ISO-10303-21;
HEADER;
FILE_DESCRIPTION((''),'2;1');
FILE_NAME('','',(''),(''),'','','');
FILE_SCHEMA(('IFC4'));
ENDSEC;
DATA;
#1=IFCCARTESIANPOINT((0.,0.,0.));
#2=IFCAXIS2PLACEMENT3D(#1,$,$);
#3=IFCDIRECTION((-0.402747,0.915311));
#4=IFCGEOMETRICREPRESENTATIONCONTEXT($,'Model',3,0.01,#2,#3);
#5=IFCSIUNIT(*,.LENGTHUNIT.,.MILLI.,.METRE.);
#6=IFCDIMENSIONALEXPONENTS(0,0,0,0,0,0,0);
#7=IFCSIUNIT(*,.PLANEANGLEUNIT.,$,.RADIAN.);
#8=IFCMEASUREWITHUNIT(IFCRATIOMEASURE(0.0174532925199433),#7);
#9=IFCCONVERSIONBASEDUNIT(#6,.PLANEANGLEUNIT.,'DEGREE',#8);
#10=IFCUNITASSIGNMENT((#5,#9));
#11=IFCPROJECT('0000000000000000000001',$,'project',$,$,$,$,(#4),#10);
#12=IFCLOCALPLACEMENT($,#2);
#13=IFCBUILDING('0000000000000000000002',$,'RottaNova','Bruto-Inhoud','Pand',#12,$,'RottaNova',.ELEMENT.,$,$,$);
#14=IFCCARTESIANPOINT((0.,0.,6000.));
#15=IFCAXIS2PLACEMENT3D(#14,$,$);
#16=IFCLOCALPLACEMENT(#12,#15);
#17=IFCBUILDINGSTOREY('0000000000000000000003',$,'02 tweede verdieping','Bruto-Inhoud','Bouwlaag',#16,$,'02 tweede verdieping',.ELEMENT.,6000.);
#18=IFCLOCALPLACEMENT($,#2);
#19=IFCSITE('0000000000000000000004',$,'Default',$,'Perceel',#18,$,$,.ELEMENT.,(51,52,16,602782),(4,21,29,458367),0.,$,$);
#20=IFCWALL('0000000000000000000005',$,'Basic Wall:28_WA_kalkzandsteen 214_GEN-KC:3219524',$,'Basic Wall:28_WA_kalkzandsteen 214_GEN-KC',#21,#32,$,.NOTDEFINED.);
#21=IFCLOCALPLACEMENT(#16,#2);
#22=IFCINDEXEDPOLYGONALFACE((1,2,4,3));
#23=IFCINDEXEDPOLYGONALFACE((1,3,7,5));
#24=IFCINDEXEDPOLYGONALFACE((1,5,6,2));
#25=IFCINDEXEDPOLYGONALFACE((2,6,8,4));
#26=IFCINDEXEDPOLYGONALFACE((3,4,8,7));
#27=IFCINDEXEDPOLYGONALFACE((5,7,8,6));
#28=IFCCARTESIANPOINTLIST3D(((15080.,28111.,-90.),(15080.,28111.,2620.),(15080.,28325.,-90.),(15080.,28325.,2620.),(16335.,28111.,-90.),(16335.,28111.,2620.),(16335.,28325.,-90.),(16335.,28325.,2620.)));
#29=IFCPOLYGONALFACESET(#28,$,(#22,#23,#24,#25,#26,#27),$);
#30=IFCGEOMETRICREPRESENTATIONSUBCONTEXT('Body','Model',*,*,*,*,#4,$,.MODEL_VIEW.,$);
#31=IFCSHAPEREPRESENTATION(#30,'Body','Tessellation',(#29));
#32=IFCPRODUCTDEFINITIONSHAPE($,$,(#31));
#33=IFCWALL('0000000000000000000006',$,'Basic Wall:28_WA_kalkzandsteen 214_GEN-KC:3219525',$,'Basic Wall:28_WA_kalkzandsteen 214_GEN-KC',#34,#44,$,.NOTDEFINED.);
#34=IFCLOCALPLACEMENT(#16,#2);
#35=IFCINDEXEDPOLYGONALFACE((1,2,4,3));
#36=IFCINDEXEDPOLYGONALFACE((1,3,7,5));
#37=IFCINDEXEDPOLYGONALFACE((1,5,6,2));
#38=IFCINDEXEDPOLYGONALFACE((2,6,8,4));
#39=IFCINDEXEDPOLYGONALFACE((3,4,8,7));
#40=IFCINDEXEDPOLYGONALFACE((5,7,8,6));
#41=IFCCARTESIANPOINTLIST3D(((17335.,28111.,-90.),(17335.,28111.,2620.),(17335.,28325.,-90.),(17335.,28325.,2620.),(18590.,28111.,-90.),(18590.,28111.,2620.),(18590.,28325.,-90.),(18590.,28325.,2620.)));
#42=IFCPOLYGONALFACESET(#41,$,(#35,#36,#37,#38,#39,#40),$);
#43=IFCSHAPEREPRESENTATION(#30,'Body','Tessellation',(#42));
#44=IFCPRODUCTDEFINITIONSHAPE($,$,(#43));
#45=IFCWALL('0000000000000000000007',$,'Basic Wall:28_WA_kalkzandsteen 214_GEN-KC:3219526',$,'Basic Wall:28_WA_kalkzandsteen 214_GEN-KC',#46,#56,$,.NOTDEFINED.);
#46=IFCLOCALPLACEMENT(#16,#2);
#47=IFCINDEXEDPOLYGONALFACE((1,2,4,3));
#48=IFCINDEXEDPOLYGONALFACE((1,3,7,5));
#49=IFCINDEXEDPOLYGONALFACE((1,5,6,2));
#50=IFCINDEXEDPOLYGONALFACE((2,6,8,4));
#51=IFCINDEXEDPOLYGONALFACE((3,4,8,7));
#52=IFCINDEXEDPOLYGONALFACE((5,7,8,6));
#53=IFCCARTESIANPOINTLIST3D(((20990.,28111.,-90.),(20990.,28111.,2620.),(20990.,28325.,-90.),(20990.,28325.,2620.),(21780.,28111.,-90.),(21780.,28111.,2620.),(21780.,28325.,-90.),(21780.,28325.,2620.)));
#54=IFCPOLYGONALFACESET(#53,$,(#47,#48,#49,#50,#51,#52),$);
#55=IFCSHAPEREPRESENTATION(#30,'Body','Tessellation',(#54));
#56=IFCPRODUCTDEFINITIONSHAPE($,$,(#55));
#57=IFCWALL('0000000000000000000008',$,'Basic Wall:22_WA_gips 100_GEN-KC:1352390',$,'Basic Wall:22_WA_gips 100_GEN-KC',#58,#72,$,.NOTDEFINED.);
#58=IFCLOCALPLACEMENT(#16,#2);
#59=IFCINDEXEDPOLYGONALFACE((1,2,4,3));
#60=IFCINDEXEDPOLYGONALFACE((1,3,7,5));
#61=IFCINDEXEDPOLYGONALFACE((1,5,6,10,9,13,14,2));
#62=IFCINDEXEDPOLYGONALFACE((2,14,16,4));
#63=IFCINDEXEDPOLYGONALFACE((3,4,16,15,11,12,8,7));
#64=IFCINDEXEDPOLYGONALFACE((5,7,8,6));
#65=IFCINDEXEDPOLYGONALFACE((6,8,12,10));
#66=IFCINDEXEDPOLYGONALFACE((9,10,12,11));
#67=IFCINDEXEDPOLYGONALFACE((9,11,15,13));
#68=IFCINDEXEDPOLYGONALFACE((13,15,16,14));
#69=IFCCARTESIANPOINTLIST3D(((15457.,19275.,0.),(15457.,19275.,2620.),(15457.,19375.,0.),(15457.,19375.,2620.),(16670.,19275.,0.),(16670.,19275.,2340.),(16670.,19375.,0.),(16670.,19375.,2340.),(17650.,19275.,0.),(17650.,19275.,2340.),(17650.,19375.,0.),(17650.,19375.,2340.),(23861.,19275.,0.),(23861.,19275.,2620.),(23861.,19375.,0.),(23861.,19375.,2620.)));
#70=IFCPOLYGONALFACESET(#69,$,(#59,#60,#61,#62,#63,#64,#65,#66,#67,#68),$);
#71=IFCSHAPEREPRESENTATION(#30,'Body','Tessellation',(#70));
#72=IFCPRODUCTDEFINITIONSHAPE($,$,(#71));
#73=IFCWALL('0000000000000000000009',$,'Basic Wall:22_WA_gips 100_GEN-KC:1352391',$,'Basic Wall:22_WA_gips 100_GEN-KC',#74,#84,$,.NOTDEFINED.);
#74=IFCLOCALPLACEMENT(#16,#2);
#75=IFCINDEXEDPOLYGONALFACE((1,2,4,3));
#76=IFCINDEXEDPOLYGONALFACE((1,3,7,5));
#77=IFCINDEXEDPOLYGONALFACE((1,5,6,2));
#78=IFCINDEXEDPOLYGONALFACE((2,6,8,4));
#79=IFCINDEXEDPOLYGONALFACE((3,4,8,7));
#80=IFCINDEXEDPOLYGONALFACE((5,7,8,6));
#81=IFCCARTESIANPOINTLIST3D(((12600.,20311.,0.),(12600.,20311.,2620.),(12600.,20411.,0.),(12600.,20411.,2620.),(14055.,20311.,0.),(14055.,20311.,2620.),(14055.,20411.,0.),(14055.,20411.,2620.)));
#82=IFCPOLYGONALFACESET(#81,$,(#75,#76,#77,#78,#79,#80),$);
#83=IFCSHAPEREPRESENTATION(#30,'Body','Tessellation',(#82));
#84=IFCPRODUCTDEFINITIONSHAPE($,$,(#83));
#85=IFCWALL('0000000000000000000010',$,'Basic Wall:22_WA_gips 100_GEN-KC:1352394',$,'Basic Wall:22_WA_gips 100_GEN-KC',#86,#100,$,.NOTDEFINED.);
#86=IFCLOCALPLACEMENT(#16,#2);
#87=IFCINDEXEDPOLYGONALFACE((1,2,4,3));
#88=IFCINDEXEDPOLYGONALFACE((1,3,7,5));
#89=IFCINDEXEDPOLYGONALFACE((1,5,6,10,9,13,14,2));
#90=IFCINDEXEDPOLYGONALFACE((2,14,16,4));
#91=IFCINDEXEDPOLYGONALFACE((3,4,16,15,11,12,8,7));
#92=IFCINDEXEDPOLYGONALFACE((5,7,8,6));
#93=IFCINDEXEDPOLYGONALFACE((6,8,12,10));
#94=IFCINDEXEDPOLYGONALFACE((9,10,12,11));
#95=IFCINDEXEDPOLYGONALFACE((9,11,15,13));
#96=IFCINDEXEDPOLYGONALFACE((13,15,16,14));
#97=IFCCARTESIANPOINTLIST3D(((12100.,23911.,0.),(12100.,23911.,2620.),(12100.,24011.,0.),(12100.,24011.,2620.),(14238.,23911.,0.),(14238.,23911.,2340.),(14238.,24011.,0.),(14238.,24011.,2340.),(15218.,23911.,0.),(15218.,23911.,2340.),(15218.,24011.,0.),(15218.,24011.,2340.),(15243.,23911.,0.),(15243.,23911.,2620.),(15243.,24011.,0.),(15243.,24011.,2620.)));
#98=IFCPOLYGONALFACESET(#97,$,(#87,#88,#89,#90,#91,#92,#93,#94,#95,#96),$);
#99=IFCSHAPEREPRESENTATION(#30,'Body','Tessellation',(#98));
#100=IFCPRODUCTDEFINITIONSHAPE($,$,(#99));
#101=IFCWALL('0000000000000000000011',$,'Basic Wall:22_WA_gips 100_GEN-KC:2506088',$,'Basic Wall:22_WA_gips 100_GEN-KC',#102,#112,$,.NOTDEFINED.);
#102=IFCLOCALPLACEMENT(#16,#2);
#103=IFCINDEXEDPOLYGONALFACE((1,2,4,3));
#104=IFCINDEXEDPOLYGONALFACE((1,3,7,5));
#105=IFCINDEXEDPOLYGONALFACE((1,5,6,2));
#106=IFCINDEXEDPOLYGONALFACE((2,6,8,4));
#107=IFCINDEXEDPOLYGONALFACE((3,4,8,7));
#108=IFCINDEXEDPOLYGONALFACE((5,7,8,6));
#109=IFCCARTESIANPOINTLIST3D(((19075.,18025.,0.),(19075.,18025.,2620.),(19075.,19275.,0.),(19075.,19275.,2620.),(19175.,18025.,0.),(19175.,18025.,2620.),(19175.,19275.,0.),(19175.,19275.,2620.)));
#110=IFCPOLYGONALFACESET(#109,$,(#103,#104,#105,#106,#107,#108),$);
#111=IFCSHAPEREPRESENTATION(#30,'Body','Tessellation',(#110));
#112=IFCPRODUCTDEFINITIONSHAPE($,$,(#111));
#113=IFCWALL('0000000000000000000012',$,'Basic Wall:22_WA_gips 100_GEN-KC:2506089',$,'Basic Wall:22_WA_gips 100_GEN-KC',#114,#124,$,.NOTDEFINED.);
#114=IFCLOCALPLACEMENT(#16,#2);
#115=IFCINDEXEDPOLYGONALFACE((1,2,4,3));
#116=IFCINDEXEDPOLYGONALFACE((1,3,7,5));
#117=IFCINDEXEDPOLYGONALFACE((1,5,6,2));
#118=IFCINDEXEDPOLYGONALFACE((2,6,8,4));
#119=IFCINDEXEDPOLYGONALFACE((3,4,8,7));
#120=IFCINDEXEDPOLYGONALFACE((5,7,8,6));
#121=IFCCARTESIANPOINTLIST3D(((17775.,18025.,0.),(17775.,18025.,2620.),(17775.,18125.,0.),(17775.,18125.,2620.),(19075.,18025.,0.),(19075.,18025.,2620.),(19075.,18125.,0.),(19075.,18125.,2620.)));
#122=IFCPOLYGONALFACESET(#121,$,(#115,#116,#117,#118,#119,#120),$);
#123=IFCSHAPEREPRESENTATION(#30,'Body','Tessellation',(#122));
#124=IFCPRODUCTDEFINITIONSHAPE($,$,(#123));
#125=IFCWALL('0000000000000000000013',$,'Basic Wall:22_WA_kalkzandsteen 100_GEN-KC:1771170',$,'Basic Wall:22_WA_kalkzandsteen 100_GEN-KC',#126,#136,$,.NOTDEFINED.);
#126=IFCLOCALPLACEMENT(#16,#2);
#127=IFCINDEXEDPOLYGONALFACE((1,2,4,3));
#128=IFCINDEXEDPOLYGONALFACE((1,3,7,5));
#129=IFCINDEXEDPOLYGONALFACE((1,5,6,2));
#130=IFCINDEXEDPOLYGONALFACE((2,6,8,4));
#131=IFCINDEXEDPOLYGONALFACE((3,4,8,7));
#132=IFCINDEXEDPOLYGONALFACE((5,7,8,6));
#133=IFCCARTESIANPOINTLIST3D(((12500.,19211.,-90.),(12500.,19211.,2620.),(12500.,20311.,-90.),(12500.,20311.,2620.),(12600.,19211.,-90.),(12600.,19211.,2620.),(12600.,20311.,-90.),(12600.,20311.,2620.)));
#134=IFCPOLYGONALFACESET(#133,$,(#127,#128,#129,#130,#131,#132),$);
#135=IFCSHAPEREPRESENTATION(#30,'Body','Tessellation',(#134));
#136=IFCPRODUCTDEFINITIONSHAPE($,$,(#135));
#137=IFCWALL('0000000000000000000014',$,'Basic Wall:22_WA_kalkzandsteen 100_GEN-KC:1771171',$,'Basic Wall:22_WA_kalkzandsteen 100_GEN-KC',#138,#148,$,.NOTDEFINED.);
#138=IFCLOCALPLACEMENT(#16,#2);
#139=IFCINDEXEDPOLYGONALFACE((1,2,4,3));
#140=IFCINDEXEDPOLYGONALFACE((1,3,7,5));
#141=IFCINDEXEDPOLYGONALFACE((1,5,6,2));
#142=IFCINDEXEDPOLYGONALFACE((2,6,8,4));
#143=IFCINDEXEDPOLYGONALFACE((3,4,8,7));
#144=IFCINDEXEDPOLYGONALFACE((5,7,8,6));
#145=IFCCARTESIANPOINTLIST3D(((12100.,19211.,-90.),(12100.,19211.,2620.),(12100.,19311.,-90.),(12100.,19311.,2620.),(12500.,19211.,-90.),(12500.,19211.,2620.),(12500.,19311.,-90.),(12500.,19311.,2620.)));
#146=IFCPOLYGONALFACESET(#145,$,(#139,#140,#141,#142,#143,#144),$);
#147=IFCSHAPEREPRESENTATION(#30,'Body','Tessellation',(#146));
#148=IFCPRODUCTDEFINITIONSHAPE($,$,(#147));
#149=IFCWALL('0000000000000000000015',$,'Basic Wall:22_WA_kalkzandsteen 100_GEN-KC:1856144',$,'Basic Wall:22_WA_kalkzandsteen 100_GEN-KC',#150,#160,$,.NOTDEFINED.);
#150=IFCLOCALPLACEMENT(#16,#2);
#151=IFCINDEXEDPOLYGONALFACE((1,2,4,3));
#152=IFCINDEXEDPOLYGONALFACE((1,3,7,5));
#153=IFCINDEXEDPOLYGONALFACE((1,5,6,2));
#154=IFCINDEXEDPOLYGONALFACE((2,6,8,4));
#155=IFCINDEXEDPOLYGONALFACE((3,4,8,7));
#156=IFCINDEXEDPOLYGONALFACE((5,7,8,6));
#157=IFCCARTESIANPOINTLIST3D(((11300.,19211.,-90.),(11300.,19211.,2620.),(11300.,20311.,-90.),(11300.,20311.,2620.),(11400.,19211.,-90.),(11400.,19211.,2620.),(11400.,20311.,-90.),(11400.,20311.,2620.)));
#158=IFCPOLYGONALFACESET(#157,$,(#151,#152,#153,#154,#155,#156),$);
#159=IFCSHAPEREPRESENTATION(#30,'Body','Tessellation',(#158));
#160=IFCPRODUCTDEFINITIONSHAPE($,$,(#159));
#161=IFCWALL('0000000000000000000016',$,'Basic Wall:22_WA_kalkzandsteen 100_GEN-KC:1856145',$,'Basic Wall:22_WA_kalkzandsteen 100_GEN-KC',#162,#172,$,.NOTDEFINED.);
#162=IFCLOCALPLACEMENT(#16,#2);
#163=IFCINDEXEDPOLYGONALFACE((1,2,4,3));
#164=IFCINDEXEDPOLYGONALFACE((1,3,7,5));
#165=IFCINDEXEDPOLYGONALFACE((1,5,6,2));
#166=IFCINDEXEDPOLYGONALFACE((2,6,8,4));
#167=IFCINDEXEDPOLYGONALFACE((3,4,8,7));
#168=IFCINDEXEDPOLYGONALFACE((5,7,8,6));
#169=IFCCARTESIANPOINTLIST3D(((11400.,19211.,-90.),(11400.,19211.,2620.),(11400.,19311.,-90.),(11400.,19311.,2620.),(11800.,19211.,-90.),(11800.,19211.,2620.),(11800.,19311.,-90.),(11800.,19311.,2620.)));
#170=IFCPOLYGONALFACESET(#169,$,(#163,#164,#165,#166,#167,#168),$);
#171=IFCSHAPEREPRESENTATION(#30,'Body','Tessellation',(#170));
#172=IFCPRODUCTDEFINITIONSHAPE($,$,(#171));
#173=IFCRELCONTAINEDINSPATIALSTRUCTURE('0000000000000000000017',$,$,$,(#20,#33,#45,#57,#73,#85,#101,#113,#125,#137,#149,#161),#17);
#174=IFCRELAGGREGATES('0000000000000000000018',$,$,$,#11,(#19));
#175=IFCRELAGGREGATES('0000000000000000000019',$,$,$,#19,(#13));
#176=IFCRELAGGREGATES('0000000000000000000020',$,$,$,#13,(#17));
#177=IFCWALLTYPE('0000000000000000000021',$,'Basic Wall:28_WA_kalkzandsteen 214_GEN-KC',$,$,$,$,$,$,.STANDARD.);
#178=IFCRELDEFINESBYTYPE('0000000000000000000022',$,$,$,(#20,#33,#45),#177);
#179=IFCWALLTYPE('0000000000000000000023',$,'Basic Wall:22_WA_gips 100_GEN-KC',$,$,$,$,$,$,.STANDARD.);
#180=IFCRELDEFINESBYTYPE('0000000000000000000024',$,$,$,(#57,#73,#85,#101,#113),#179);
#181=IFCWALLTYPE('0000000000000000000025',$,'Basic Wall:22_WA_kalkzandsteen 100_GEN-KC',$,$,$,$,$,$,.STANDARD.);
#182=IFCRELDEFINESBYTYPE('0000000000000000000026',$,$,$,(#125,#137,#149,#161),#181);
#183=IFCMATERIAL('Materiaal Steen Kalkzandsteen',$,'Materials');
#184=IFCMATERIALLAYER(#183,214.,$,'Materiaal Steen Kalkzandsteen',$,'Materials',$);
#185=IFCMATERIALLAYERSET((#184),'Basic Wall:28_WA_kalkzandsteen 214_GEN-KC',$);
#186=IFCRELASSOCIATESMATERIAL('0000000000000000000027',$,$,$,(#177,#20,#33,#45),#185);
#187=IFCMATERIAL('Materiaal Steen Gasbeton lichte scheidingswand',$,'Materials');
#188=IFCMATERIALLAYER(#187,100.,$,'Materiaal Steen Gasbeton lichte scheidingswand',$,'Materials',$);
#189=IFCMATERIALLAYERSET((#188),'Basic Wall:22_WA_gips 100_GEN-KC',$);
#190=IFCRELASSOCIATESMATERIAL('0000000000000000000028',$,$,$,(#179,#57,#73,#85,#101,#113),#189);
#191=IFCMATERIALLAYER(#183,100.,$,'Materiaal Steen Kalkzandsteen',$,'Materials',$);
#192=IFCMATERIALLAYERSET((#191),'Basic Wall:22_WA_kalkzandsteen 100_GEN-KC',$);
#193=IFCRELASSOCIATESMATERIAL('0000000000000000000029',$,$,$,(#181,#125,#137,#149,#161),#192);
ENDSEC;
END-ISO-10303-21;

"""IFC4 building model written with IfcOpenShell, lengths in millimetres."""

from ifc_helpers import new_model, entity, si_unit, converted_unit, direction, frame, frame_2d, origin, place, context, subcontext, project, spatial, rectangle, extrude, material, layer, layer_set, type_object, element, save


model = new_model("IFC4")

# Units and contexts
model_context = context("Model", 3, precision=0.01, world=origin(), true_north=direction((-0.402747, 0.915311)))
body_context = subcontext(model_context, "Body", "Model", "MODEL_VIEW")
ifc_project = project(units=[si_unit("LENGTHUNIT", "METRE", prefix="MILLI"), converted_unit("PLANEANGLEUNIT", "DEGREE", entity("IfcRatioMeasure", 0.0174532925199433), si_unit("PLANEANGLEUNIT", "RADIAN"), dimensions=[0, 0, 0, 0, 0, 0, 0])], contexts=[model_context])

# Site, building, storey
site_placement = place(None, origin())
site = spatial("IfcSite", under=ifc_project, at=site_placement, Name="Default", ObjectType="Perceel", CompositionType="ELEMENT", RefLatitude=(51, 52, 16, 602782), RefLongitude=(4, 21, 29, 458367), RefElevation=0.0)
building_placement = place(None, origin())
building = spatial("IfcBuilding", under=site, at=building_placement, Name="RottaNova", Description="Bruto-Inhoud", ObjectType="Pand", LongName="RottaNova", CompositionType="ELEMENT")
storey_placement = place(building_placement, frame((0.0, 0.0, 6000.0)))
storey = spatial("IfcBuildingStorey", under=building, at=storey_placement, Name="02 tweede verdieping", Description="Bruto-Inhoud", ObjectType="Bouwlaag", LongName="02 tweede verdieping", CompositionType="ELEMENT", Elevation=6000.0)

# Walls
ifc_material_1 = material(Name="Materiaal Steen Kalkzandsteen", Category="Materials")
ifc_layer_1 = layer(ifc_material_1, 214.0, Name="Materiaal Steen Kalkzandsteen", Category="Materials")
ifc_layer_set_1 = layer_set([ifc_layer_1], Name="Basic Wall:28_WA_kalkzandsteen 214_GEN-KC")
wall_type_1 = type_object("IfcWallType", Name="Basic Wall:28_WA_kalkzandsteen 214_GEN-KC", PredefinedType="STANDARD", material=ifc_layer_set_1)
wall_1_placement = place(storey_placement, frame((15080.0, 28218.0, -90.0)))
element("IfcWall", 1, at=wall_1_placement, inside=storey, type_object=wall_type_1, material=ifc_layer_set_1, Name="Basic Wall:28_WA_kalkzandsteen 214_GEN-KC:3219524", ObjectType="Basic Wall:28_WA_kalkzandsteen 214_GEN-KC", PredefinedType="NOTDEFINED", context=body_context, shape_type="SweptSolid", body=[
    extrude(rectangle(XDim=1255.0, YDim=214.0, at=frame_2d((627.5, 0.0), x_axis=(-1.0, 0.0))), origin(), (0.0, 0.0, 1.0), 2710.0),
])
wall_2_placement = place(storey_placement, frame((17335.0, 28218.0, -90.0)))
element("IfcWall", 2, at=wall_2_placement, inside=storey, type_object=wall_type_1, material=ifc_layer_set_1, Name="Basic Wall:28_WA_kalkzandsteen 214_GEN-KC:3219525", ObjectType="Basic Wall:28_WA_kalkzandsteen 214_GEN-KC", PredefinedType="NOTDEFINED", context=body_context, shape_type="SweptSolid", body=[
    extrude(rectangle(XDim=1255.0, YDim=214.0, at=frame_2d((627.5, 0.0), x_axis=(-1.0, 0.0))), origin(), (0.0, 0.0, 1.0), 2710.0),
])
wall_3_placement = place(storey_placement, frame((20990.0, 28218.0, -90.0)))
element("IfcWall", 3, at=wall_3_placement, inside=storey, type_object=wall_type_1, material=ifc_layer_set_1, Name="Basic Wall:28_WA_kalkzandsteen 214_GEN-KC:3219526", ObjectType="Basic Wall:28_WA_kalkzandsteen 214_GEN-KC", PredefinedType="NOTDEFINED", context=body_context, shape_type="SweptSolid", body=[
    extrude(rectangle(XDim=790.0, YDim=214.0, at=frame_2d((395.0, 0.0), x_axis=(-1.0, 0.0))), origin(), (0.0, 0.0, 1.0), 2710.0),
])

# Wall, opening
ifc_material_2 = material(Name="Materiaal Steen Gasbeton lichte scheidingswand", Category="Materials")
ifc_layer_2 = layer(ifc_material_2, 100.0, Name="Materiaal Steen Gasbeton lichte scheidingswand", Category="Materials")
ifc_layer_set_2 = layer_set([ifc_layer_2], Name="Basic Wall:22_WA_gips 100_GEN-KC")
wall_type_2 = type_object("IfcWallType", Name="Basic Wall:22_WA_gips 100_GEN-KC", PredefinedType="STANDARD", material=ifc_layer_set_2)
wall_4_placement = place(storey_placement, frame((23861.0, 19325.0, 0.0), z_axis=(0.0, 0.0, 1.0), x_axis=(-1.0, 0.0, 0.0)))
wall_4 = element("IfcWall", 4, at=wall_4_placement, inside=storey, type_object=wall_type_2, material=ifc_layer_set_2, Name="Basic Wall:22_WA_gips 100_GEN-KC:1352390", ObjectType="Basic Wall:22_WA_gips 100_GEN-KC", PredefinedType="NOTDEFINED", context=body_context, shape_type="SweptSolid", body=[
    extrude(rectangle(XDim=8404.0, YDim=100.0, at=frame_2d((4202.0, 0.0), x_axis=(-1.0, 0.0))), origin(), (0.0, 0.0, 1.0), 2620.0),
])
opening_1_placement = place(wall_4_placement, frame((7191.0, 50.0, -90.0)))
element("IfcOpeningElement", 5, at=opening_1_placement, cuts=wall_4, PredefinedType="OPENING", context=body_context, shape_type="SweptSolid", body=[
    extrude(rectangle(XDim=2430.0, YDim=980.0, at=frame_2d((1215.0, 490.0), x_axis=(1.0, 0.0))), frame((0.0, 0.0, 0.0), z_axis=(0.0, -1.0, 0.0), x_axis=(0.0, 0.0, 1.0)), (0.0, 0.0, 1.0), 100.0),
])

# Wall
wall_5_placement = place(storey_placement, frame((14055.0, 20361.0, 0.0), z_axis=(0.0, 0.0, 1.0), x_axis=(-1.0, 0.0, 0.0)))
element("IfcWall", 6, at=wall_5_placement, inside=storey, type_object=wall_type_2, material=ifc_layer_set_2, Name="Basic Wall:22_WA_gips 100_GEN-KC:1352391", ObjectType="Basic Wall:22_WA_gips 100_GEN-KC", PredefinedType="NOTDEFINED", context=body_context, shape_type="SweptSolid", body=[
    extrude(rectangle(XDim=1455.0, YDim=100.0, at=frame_2d((727.5, 0.0), x_axis=(-1.0, 0.0))), origin(), (0.0, 0.0, 1.0), 2620.0),
])

# Wall, opening
wall_6_placement = place(storey_placement, frame((15243.0, 23961.0, 0.0), z_axis=(0.0, 0.0, 1.0), x_axis=(-1.0, 0.0, 0.0)))
wall_6 = element("IfcWall", 7, at=wall_6_placement, inside=storey, type_object=wall_type_2, material=ifc_layer_set_2, Name="Basic Wall:22_WA_gips 100_GEN-KC:1352394", ObjectType="Basic Wall:22_WA_gips 100_GEN-KC", PredefinedType="NOTDEFINED", context=body_context, shape_type="SweptSolid", body=[
    extrude(rectangle(XDim=3143.0, YDim=100.0, at=frame_2d((1571.5, 0.0), x_axis=(-1.0, 0.0))), origin(), (0.0, 0.0, 1.0), 2620.0),
])
opening_2_placement = place(wall_6_placement, frame((1005.0, 50.0, -90.0)))
element("IfcOpeningElement", 8, at=opening_2_placement, cuts=wall_6, PredefinedType="OPENING", context=body_context, shape_type="SweptSolid", body=[
    extrude(rectangle(XDim=2430.0, YDim=980.0, at=frame_2d((1215.0, 490.0), x_axis=(1.0, 0.0))), frame((0.0, 0.0, 0.0), z_axis=(0.0, -1.0, 0.0), x_axis=(0.0, 0.0, 1.0)), (0.0, 0.0, 1.0), 100.0),
])

# Walls
wall_7_placement = place(storey_placement, frame((19125.0, 19275.0, 0.0), z_axis=(0.0, 0.0, 1.0), x_axis=(0.0, -1.0, 0.0)))
element("IfcWall", 9, at=wall_7_placement, inside=storey, type_object=wall_type_2, material=ifc_layer_set_2, Name="Basic Wall:22_WA_gips 100_GEN-KC:2506088", ObjectType="Basic Wall:22_WA_gips 100_GEN-KC", PredefinedType="NOTDEFINED", context=body_context, shape_type="SweptSolid", body=[
    extrude(rectangle(XDim=1250.0, YDim=100.0, at=frame_2d((625.0, 0.0), x_axis=(-1.0, 0.0))), origin(), (0.0, 0.0, 1.0), 2620.0),
])
wall_8_placement = place(storey_placement, frame((19075.0, 18075.0, 0.0), z_axis=(0.0, 0.0, 1.0), x_axis=(-1.0, 0.0, 0.0)))
element("IfcWall", 10, at=wall_8_placement, inside=storey, type_object=wall_type_2, material=ifc_layer_set_2, Name="Basic Wall:22_WA_gips 100_GEN-KC:2506089", ObjectType="Basic Wall:22_WA_gips 100_GEN-KC", PredefinedType="NOTDEFINED", context=body_context, shape_type="SweptSolid", body=[
    extrude(rectangle(XDim=1300.0, YDim=100.0, at=frame_2d((650.0, 0.0), x_axis=(-1.0, 0.0))), origin(), (0.0, 0.0, 1.0), 2620.0),
])
ifc_layer_3 = layer(ifc_material_1, 100.0, Name="Materiaal Steen Kalkzandsteen", Category="Materials")
ifc_layer_set_3 = layer_set([ifc_layer_3], Name="Basic Wall:22_WA_kalkzandsteen 100_GEN-KC")
wall_type_3 = type_object("IfcWallType", Name="Basic Wall:22_WA_kalkzandsteen 100_GEN-KC", PredefinedType="STANDARD", material=ifc_layer_set_3)
wall_9_placement = place(storey_placement, frame((12550.0, 20311.0, -90.0), z_axis=(0.0, 0.0, 1.0), x_axis=(0.0, -1.0, 0.0)))
element("IfcWall", 11, at=wall_9_placement, inside=storey, type_object=wall_type_3, material=ifc_layer_set_3, Name="Basic Wall:22_WA_kalkzandsteen 100_GEN-KC:1771170", ObjectType="Basic Wall:22_WA_kalkzandsteen 100_GEN-KC", PredefinedType="NOTDEFINED", context=body_context, shape_type="SweptSolid", body=[
    extrude(rectangle(XDim=1100.0, YDim=100.0, at=frame_2d((550.0, 0.0), x_axis=(-1.0, 0.0))), origin(), (0.0, 0.0, 1.0), 2710.0),
])
wall_10_placement = place(storey_placement, frame((12500.0, 19261.0, -90.0), z_axis=(0.0, 0.0, 1.0), x_axis=(-1.0, 0.0, 0.0)))
element("IfcWall", 12, at=wall_10_placement, inside=storey, type_object=wall_type_3, material=ifc_layer_set_3, Name="Basic Wall:22_WA_kalkzandsteen 100_GEN-KC:1771171", ObjectType="Basic Wall:22_WA_kalkzandsteen 100_GEN-KC", PredefinedType="NOTDEFINED", context=body_context, shape_type="SweptSolid", body=[
    extrude(rectangle(XDim=400.0, YDim=100.0, at=frame_2d((200.0, 0.0), x_axis=(-1.0, 0.0))), origin(), (0.0, 0.0, 1.0), 2710.0),
])
wall_11_placement = place(storey_placement, frame((11350.0, 20311.0, -90.0), z_axis=(0.0, 0.0, 1.0), x_axis=(0.0, -1.0, 0.0)))
element("IfcWall", 13, at=wall_11_placement, inside=storey, type_object=wall_type_3, material=ifc_layer_set_3, Name="Basic Wall:22_WA_kalkzandsteen 100_GEN-KC:1856144", ObjectType="Basic Wall:22_WA_kalkzandsteen 100_GEN-KC", PredefinedType="NOTDEFINED", context=body_context, shape_type="SweptSolid", body=[
    extrude(rectangle(XDim=1100.0, YDim=100.0, at=frame_2d((550.0, 0.0), x_axis=(-1.0, 0.0))), origin(), (0.0, 0.0, 1.0), 2710.0),
])
wall_12_placement = place(storey_placement, frame((11400.0, 19261.0, -90.0)))
element("IfcWall", 14, at=wall_12_placement, inside=storey, type_object=wall_type_3, material=ifc_layer_set_3, Name="Basic Wall:22_WA_kalkzandsteen 100_GEN-KC:1856145", ObjectType="Basic Wall:22_WA_kalkzandsteen 100_GEN-KC", PredefinedType="NOTDEFINED", context=body_context, shape_type="SweptSolid", body=[
    extrude(rectangle(XDim=400.0, YDim=100.0, at=frame_2d((200.0, 0.0), x_axis=(-1.0, 0.0))), origin(), (0.0, 0.0, 1.0), 2710.0),
])

save(model, "model.ifc")
